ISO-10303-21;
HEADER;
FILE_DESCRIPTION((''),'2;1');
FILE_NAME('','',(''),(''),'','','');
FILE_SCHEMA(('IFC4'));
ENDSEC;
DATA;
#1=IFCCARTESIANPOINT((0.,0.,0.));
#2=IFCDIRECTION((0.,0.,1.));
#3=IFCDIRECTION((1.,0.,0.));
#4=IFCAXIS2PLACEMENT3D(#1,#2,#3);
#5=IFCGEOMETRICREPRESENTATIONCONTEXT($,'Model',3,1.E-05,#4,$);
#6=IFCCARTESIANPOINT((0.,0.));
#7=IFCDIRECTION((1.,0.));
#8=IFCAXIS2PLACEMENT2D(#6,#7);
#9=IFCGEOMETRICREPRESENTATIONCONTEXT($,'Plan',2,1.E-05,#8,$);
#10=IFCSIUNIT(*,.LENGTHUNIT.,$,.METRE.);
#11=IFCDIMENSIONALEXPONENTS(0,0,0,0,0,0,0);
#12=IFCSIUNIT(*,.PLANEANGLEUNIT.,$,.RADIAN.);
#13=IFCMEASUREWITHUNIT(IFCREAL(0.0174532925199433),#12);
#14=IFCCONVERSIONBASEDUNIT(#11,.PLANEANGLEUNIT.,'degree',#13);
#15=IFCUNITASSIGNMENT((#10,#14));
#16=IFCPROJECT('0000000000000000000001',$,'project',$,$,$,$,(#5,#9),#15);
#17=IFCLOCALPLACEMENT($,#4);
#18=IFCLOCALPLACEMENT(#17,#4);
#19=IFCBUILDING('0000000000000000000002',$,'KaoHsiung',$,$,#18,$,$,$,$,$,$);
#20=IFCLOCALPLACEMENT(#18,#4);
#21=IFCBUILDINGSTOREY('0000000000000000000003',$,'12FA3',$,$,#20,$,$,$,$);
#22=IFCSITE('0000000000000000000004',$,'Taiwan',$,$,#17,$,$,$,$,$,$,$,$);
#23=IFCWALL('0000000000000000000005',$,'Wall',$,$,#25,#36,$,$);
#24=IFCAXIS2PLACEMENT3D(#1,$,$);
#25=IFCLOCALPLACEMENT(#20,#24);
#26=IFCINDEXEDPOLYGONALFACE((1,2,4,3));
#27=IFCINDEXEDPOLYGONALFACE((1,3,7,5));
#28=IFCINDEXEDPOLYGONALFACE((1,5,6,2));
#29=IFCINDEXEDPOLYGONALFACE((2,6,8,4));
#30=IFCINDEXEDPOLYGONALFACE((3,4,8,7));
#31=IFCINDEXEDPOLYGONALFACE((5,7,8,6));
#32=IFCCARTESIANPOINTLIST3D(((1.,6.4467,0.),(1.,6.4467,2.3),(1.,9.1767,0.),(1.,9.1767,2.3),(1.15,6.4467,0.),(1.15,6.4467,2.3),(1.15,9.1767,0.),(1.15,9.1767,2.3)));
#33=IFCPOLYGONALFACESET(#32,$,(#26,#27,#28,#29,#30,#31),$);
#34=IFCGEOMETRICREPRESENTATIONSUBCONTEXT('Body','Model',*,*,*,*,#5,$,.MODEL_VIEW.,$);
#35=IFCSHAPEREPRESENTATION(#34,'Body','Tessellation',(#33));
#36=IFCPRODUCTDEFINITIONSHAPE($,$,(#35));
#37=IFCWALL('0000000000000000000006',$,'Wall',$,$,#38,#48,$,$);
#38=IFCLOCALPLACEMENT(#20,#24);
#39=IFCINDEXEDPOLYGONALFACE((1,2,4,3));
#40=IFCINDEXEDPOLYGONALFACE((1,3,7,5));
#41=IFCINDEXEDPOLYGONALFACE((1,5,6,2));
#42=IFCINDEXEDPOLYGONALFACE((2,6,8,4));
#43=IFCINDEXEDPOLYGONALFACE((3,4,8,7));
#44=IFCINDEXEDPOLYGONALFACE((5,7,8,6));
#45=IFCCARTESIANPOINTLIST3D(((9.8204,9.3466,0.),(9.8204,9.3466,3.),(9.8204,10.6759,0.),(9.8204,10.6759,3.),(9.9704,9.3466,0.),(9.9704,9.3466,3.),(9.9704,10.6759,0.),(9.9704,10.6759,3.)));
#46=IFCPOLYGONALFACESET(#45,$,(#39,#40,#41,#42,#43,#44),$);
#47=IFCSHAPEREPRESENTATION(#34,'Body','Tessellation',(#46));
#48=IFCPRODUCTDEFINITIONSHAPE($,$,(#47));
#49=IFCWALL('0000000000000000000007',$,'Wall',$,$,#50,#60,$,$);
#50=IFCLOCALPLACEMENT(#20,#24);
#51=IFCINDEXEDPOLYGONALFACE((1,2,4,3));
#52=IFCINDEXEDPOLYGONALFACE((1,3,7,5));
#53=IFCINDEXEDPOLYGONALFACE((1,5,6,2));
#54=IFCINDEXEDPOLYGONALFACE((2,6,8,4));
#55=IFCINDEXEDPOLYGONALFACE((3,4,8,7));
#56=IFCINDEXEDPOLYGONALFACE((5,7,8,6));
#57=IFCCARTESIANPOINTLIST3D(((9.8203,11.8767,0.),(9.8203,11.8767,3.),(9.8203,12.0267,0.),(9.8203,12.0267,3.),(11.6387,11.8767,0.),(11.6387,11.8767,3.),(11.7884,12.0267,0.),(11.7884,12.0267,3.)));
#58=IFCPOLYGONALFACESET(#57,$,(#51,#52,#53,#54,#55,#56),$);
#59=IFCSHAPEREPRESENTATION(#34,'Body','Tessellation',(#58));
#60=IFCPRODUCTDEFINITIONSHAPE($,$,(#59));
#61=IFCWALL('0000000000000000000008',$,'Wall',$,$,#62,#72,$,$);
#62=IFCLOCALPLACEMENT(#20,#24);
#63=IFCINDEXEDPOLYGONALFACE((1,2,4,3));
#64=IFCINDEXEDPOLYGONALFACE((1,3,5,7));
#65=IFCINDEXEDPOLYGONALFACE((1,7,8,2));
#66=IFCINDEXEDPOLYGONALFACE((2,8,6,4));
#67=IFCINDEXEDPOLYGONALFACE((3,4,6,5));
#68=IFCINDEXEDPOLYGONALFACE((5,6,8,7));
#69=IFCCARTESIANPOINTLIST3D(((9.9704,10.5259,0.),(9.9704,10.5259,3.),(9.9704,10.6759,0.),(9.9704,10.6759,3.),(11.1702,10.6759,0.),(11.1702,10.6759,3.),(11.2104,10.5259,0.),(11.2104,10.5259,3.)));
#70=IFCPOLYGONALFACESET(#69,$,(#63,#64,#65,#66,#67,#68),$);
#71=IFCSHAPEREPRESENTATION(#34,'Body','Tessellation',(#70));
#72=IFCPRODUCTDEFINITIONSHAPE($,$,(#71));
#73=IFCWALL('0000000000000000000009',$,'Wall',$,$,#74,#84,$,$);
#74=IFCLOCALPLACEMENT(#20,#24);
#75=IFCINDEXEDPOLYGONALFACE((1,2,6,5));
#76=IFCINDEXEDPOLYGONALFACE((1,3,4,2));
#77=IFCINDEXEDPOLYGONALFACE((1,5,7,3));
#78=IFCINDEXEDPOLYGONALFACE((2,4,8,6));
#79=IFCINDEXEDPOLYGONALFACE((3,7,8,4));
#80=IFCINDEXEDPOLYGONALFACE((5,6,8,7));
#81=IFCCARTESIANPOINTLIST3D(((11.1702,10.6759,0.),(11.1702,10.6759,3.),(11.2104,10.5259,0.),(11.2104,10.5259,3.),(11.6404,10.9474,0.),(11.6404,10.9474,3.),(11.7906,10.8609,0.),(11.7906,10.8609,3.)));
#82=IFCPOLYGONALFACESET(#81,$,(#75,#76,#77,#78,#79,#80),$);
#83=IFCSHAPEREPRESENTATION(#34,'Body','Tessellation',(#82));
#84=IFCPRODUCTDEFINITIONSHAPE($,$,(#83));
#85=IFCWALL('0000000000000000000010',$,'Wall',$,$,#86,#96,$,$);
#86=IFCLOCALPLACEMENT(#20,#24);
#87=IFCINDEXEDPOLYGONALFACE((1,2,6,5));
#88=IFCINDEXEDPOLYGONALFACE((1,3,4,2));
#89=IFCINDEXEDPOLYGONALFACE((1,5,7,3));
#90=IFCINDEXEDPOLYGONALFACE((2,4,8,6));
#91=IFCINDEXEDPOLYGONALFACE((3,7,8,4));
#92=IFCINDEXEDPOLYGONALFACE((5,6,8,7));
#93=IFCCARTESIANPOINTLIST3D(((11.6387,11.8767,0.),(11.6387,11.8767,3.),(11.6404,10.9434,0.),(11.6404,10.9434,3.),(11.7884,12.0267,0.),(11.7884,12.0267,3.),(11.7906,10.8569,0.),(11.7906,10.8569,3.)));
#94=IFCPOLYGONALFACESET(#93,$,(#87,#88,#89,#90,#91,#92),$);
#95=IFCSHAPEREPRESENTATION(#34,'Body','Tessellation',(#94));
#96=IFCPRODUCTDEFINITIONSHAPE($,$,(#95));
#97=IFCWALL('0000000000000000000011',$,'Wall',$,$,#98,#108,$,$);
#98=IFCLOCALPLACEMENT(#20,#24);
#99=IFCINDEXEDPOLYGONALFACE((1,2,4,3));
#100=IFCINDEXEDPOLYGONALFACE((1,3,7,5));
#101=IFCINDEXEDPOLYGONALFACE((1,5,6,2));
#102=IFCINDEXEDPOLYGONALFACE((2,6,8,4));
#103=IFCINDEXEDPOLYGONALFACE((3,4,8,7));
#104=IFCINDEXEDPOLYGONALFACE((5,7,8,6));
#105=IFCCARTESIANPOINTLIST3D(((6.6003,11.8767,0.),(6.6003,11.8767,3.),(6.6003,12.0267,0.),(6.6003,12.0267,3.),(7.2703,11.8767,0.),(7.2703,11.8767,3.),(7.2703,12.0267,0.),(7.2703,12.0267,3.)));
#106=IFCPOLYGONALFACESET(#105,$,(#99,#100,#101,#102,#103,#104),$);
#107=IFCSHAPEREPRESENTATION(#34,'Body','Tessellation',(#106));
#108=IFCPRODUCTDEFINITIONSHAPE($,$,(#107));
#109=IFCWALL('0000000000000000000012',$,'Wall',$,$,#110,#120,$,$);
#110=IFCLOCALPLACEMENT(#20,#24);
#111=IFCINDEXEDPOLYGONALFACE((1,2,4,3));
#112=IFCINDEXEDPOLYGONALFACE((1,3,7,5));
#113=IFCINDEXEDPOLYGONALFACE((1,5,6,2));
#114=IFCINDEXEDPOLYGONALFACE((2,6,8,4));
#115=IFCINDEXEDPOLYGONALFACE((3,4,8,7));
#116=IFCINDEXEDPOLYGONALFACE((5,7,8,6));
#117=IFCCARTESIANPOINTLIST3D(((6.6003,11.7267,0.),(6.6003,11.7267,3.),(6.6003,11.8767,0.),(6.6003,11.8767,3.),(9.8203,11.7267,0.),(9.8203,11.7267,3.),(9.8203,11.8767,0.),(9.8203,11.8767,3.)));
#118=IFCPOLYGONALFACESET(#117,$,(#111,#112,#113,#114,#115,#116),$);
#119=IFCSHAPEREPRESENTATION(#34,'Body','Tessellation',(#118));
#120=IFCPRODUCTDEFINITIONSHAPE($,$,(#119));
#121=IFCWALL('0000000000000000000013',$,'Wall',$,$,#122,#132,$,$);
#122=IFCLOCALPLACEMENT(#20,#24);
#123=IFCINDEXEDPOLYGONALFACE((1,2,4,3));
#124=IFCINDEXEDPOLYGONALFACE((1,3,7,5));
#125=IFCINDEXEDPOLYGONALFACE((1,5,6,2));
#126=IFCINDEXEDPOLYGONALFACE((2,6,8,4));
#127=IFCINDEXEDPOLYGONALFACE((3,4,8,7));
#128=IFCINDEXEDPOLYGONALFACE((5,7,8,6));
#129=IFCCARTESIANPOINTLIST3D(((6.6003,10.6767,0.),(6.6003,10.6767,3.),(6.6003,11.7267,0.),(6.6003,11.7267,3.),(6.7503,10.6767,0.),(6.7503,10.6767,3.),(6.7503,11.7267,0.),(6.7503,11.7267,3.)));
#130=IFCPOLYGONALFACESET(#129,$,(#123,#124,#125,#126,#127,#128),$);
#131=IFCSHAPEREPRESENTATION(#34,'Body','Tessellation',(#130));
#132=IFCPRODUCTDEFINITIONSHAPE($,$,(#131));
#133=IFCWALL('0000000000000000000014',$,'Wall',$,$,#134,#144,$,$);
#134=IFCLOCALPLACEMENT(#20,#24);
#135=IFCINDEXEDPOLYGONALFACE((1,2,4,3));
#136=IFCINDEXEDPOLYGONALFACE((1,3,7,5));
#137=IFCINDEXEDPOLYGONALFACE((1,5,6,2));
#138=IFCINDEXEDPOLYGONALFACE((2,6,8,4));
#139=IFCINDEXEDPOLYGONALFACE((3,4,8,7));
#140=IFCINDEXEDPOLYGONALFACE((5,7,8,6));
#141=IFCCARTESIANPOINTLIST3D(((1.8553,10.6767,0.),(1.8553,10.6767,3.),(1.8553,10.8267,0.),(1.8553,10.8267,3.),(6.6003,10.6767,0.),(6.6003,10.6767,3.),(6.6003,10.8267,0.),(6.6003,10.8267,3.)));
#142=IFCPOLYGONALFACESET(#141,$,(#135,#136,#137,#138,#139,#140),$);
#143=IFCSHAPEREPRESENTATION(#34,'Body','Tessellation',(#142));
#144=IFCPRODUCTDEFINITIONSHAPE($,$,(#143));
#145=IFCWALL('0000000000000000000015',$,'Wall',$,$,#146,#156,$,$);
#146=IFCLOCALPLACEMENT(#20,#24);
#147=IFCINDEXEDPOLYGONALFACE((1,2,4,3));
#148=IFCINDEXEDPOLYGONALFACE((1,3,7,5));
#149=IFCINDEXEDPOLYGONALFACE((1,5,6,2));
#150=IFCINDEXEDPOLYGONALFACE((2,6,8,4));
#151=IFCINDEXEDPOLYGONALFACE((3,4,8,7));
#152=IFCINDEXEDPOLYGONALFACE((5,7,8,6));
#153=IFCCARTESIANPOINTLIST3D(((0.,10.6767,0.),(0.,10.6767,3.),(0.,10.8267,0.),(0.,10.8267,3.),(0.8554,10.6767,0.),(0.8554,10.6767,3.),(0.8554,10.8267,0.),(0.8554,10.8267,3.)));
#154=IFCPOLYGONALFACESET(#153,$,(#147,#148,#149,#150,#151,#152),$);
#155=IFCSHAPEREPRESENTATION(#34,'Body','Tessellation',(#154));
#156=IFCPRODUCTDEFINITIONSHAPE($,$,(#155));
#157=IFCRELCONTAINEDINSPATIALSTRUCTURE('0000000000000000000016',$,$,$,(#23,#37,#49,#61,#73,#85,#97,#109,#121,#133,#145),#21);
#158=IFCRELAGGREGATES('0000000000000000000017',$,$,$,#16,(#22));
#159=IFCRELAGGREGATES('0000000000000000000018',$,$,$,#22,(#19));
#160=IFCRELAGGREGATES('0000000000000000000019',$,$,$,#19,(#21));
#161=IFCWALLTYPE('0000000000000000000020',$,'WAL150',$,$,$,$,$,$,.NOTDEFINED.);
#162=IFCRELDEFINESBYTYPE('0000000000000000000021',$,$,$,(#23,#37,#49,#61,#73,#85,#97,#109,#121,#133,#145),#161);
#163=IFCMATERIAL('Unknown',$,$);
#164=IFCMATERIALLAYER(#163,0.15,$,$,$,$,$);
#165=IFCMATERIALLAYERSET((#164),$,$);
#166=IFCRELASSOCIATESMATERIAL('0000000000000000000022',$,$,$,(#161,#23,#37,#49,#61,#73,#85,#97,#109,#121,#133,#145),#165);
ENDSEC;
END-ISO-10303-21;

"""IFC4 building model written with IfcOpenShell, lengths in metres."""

from ifc_helpers import new_model, entity, si_unit, converted_unit, frame, origin_with_axes, origin_2d_with_axis, place, context, subcontext, project, spatial, line, indexed_curve, outline, extrude, material, layer, layer_set, layer_usage, type_object, element, save


model = new_model("IFC4")

# Units and contexts
model_context = context("Model", 3, precision=1e-05, world=origin_with_axes())
plan_context = context("Plan", 2, precision=1e-05, world=origin_2d_with_axis())
body_context_1 = subcontext(model_context, "Body", "Model", "MODEL_VIEW")
ifc_project = project(units=[si_unit("LENGTHUNIT", "METRE"), converted_unit("PLANEANGLEUNIT", "degree", entity("IfcReal", 0.0174532925199433), si_unit("PLANEANGLEUNIT", "RADIAN"), dimensions=[0, 0, 0, 0, 0, 0, 0])], contexts=[model_context, plan_context])

# Site, building, storey
site_placement = place(None, origin_with_axes())
site = spatial("IfcSite", under=ifc_project, at=site_placement, Name="Taiwan")
building_placement = place(site_placement, origin_with_axes())
building = spatial("IfcBuilding", under=site, at=building_placement, Name="KaoHsiung")
storey_placement = place(building_placement, origin_with_axes())
storey = spatial("IfcBuildingStorey", under=building, at=storey_placement, Name="12FA3")

# Shared definitions
ifc_material = material(Name="Unknown")

# Walls
ifc_layer_1 = layer(ifc_material, 0.15)
ifc_layer_set_1 = layer_set([ifc_layer_1])
wall_type_1 = type_object("IfcWallType", Name="WAL150", PredefinedType="NOTDEFINED", material=ifc_layer_set_1)
ifc_layer_usage_1 = layer_usage(ifc_layer_set_1, "AXIS2", "POSITIVE", 0.0)
wall_1_placement = place(storey_placement, frame((1.0, 9.1767, 0.0), z_axis=(0.0, 0.0, 1.0), x_axis=(0.0, -1.0, 0.0)))
element("IfcWall", 1, at=wall_1_placement, inside=storey, type_object=wall_type_1, material=ifc_layer_usage_1, Name="Wall", context=body_context_1, shape_type="SweptSolid", body=[
    extrude(outline(indexed_curve([(0.0, 0.0), (0.0, 0.15), (2.73, 0.15), (2.73, 0.0)], segments=[line(1, 2, 3, 4, 1)])), origin_with_axes(), (0.0, 0.0, 1.0), 2.3),
])
ifc_layer_usage_2 = layer_usage(ifc_layer_set_1, "AXIS2", "POSITIVE", 0.0)
wall_2_placement = place(storey_placement, frame((9.9704, 9.3466, 0.0), z_axis=(0.0, 0.0, 1.0), x_axis=(0.0, 1.0, 0.0)))
element("IfcWall", 2, at=wall_2_placement, inside=storey, type_object=wall_type_1, material=ifc_layer_usage_2, Name="Wall", context=body_context_1, shape_type="SweptSolid", body=[
    extrude(outline(indexed_curve([(0.0, 0.0), (0.0, 0.15), (1.3293, 0.15), (1.3293, 0.0)], segments=[line(1, 2, 3, 4, 1)])), origin_with_axes(), (0.0, 0.0, 1.0), 3.0),
])
ifc_layer_usage_3 = layer_usage(ifc_layer_set_1, "AXIS2", "POSITIVE", 0.0)
wall_3_placement = place(storey_placement, frame((11.7884, 12.0267, 0.0), z_axis=(0.0, 0.0, 1.0), x_axis=(-1.0, 0.0, 0.0)))
element("IfcWall", 3, at=wall_3_placement, inside=storey, type_object=wall_type_1, material=ifc_layer_usage_3, Name="Wall", context=body_context_1, shape_type="SweptSolid", body=[
    extrude(outline(indexed_curve([(0.0, 0.0), (0.1497, 0.15), (1.9681, 0.15), (1.9681, 0.0)], segments=[line(1, 2, 3, 4, 1)])), origin_with_axes(), (0.0, 0.0, 1.0), 3.0),
])
ifc_layer_usage_4 = layer_usage(ifc_layer_set_1, "AXIS2", "POSITIVE", 0.0)
wall_4_placement = place(storey_placement, frame((9.9704, 10.5259, 0.0), z_axis=(0.0, 0.0, 1.0), x_axis=(1.0, 0.0, 0.0)))
element("IfcWall", 4, at=wall_4_placement, inside=storey, type_object=wall_type_1, material=ifc_layer_usage_4, Name="Wall", context=body_context_1, shape_type="SweptSolid", body=[
    extrude(outline(indexed_curve([(0.0, 0.0), (0.0, 0.15), (1.1998, 0.15), (1.24, 0.0)], segments=[line(1, 2, 3, 4, 1)])), origin_with_axes(), (0.0, 0.0, 1.0), 3.0),
])
ifc_layer_usage_5 = layer_usage(ifc_layer_set_1, "AXIS2", "POSITIVE", 0.0)
wall_5_placement = place(storey_placement, frame((11.2104, 10.5259, 0.0), z_axis=(0.0, 0.0, 1.0), x_axis=(0.866026, 0.5, 0.0)))
element("IfcWall", 5, at=wall_5_placement, inside=storey, type_object=wall_type_1, material=ifc_layer_usage_5, Name="Wall", context=body_context_1, shape_type="SweptSolid", body=[
    extrude(outline(indexed_curve([(0.0, 0.0), (0.0402, 0.15), (0.5832, 0.15), (0.67, 0.0)], segments=[line(1, 2, 3, 4, 1)])), origin_with_axes(), (0.0, 0.0, 1.0), 3.0),
])
ifc_layer_usage_6 = layer_usage(ifc_layer_set_1, "AXIS2", "POSITIVE", 0.0)
wall_6_placement = place(storey_placement, frame((11.7906, 10.8569, 0.0), z_axis=(0.0, 0.0, 1.0), x_axis=(-0.001882, 0.999998, 0.0)))
element("IfcWall", 6, at=wall_6_placement, inside=storey, type_object=wall_type_1, material=ifc_layer_usage_6, Name="Wall", context=body_context_1, shape_type="SweptSolid", body=[
    extrude(outline(indexed_curve([(0.0, 0.0), (0.0868, 0.15), (1.02, 0.15), (1.1698, 0.0)], segments=[line(1, 2, 3, 4, 1)])), origin_with_axes(), (0.0, 0.0, 1.0), 3.0),
])
ifc_layer_usage_7 = layer_usage(ifc_layer_set_1, "AXIS2", "POSITIVE", 0.0)
wall_7_placement = place(storey_placement, frame((7.2703, 12.0267, 0.0), z_axis=(0.0, 0.0, 1.0), x_axis=(-1.0, 0.0, 0.0)))
element("IfcWall", 7, at=wall_7_placement, inside=storey, type_object=wall_type_1, material=ifc_layer_usage_7, Name="Wall", context=body_context_1, shape_type="SweptSolid", body=[
    extrude(outline(indexed_curve([(0.0, 0.0), (0.0, 0.15), (0.67, 0.15), (0.67, 0.0)], segments=[line(1, 2, 3, 4, 1)])), origin_with_axes(), (0.0, 0.0, 1.0), 3.0),
])
ifc_layer_usage_8 = layer_usage(ifc_layer_set_1, "AXIS2", "POSITIVE", 0.0)
wall_8_placement = place(storey_placement, frame((9.8203, 11.8767, 0.0), z_axis=(0.0, 0.0, 1.0), x_axis=(-1.0, 0.0, 0.0)))
element("IfcWall", 8, at=wall_8_placement, inside=storey, type_object=wall_type_1, material=ifc_layer_usage_8, Name="Wall", context=body_context_1, shape_type="SweptSolid", body=[
    extrude(outline(indexed_curve([(0.0, 0.0), (0.0, 0.15), (3.22, 0.15), (3.22, 0.0)], segments=[line(1, 2, 3, 4, 1)])), origin_with_axes(), (0.0, 0.0, 1.0), 3.0),
])
ifc_layer_usage_9 = layer_usage(ifc_layer_set_1, "AXIS2", "POSITIVE", 0.0)
wall_9_placement = place(storey_placement, frame((6.6003, 11.7267, 0.0), z_axis=(0.0, 0.0, 1.0), x_axis=(0.0, -1.0, 0.0)))
element("IfcWall", 9, at=wall_9_placement, inside=storey, type_object=wall_type_1, material=ifc_layer_usage_9, Name="Wall", context=body_context_1, shape_type="SweptSolid", body=[
    extrude(outline(indexed_curve([(0.0, 0.0), (0.0, 0.15), (1.05, 0.15), (1.05, 0.0)], segments=[line(1, 2, 3, 4, 1)])), origin_with_axes(), (0.0, 0.0, 1.0), 3.0),
])
ifc_layer_usage_10 = layer_usage(ifc_layer_set_1, "AXIS2", "POSITIVE", 0.0)
wall_10_placement = place(storey_placement, frame((6.6003, 10.8267, 0.0), z_axis=(0.0, 0.0, 1.0), x_axis=(-1.0, 0.0, 0.0)))
element("IfcWall", 10, at=wall_10_placement, inside=storey, type_object=wall_type_1, material=ifc_layer_usage_10, Name="Wall", context=body_context_1, shape_type="SweptSolid", body=[
    extrude(outline(indexed_curve([(0.0, 0.0), (0.0, 0.15), (4.745, 0.15), (4.745, 0.0)], segments=[line(1, 2, 3, 4, 1)])), origin_with_axes(), (0.0, 0.0, 1.0), 3.0),
])
ifc_layer_usage_11 = layer_usage(ifc_layer_set_1, "AXIS2", "POSITIVE", 0.0)
wall_11_placement = place(storey_placement, frame((0.8554, 10.8267, 0.0), z_axis=(0.0, 0.0, 1.0), x_axis=(-1.0, 0.0, 0.0)))
element("IfcWall", 11, at=wall_11_placement, inside=storey, type_object=wall_type_1, material=ifc_layer_usage_11, Name="Wall", context=body_context_1, shape_type="SweptSolid", body=[
    extrude(outline(indexed_curve([(0.0, 0.0), (0.0, 0.15), (0.8553, 0.15), (0.8553, 0.0)], segments=[line(1, 2, 3, 4, 1)])), origin_with_axes(), (0.0, 0.0, 1.0), 3.0),
])

save(model, "model.ifc")
